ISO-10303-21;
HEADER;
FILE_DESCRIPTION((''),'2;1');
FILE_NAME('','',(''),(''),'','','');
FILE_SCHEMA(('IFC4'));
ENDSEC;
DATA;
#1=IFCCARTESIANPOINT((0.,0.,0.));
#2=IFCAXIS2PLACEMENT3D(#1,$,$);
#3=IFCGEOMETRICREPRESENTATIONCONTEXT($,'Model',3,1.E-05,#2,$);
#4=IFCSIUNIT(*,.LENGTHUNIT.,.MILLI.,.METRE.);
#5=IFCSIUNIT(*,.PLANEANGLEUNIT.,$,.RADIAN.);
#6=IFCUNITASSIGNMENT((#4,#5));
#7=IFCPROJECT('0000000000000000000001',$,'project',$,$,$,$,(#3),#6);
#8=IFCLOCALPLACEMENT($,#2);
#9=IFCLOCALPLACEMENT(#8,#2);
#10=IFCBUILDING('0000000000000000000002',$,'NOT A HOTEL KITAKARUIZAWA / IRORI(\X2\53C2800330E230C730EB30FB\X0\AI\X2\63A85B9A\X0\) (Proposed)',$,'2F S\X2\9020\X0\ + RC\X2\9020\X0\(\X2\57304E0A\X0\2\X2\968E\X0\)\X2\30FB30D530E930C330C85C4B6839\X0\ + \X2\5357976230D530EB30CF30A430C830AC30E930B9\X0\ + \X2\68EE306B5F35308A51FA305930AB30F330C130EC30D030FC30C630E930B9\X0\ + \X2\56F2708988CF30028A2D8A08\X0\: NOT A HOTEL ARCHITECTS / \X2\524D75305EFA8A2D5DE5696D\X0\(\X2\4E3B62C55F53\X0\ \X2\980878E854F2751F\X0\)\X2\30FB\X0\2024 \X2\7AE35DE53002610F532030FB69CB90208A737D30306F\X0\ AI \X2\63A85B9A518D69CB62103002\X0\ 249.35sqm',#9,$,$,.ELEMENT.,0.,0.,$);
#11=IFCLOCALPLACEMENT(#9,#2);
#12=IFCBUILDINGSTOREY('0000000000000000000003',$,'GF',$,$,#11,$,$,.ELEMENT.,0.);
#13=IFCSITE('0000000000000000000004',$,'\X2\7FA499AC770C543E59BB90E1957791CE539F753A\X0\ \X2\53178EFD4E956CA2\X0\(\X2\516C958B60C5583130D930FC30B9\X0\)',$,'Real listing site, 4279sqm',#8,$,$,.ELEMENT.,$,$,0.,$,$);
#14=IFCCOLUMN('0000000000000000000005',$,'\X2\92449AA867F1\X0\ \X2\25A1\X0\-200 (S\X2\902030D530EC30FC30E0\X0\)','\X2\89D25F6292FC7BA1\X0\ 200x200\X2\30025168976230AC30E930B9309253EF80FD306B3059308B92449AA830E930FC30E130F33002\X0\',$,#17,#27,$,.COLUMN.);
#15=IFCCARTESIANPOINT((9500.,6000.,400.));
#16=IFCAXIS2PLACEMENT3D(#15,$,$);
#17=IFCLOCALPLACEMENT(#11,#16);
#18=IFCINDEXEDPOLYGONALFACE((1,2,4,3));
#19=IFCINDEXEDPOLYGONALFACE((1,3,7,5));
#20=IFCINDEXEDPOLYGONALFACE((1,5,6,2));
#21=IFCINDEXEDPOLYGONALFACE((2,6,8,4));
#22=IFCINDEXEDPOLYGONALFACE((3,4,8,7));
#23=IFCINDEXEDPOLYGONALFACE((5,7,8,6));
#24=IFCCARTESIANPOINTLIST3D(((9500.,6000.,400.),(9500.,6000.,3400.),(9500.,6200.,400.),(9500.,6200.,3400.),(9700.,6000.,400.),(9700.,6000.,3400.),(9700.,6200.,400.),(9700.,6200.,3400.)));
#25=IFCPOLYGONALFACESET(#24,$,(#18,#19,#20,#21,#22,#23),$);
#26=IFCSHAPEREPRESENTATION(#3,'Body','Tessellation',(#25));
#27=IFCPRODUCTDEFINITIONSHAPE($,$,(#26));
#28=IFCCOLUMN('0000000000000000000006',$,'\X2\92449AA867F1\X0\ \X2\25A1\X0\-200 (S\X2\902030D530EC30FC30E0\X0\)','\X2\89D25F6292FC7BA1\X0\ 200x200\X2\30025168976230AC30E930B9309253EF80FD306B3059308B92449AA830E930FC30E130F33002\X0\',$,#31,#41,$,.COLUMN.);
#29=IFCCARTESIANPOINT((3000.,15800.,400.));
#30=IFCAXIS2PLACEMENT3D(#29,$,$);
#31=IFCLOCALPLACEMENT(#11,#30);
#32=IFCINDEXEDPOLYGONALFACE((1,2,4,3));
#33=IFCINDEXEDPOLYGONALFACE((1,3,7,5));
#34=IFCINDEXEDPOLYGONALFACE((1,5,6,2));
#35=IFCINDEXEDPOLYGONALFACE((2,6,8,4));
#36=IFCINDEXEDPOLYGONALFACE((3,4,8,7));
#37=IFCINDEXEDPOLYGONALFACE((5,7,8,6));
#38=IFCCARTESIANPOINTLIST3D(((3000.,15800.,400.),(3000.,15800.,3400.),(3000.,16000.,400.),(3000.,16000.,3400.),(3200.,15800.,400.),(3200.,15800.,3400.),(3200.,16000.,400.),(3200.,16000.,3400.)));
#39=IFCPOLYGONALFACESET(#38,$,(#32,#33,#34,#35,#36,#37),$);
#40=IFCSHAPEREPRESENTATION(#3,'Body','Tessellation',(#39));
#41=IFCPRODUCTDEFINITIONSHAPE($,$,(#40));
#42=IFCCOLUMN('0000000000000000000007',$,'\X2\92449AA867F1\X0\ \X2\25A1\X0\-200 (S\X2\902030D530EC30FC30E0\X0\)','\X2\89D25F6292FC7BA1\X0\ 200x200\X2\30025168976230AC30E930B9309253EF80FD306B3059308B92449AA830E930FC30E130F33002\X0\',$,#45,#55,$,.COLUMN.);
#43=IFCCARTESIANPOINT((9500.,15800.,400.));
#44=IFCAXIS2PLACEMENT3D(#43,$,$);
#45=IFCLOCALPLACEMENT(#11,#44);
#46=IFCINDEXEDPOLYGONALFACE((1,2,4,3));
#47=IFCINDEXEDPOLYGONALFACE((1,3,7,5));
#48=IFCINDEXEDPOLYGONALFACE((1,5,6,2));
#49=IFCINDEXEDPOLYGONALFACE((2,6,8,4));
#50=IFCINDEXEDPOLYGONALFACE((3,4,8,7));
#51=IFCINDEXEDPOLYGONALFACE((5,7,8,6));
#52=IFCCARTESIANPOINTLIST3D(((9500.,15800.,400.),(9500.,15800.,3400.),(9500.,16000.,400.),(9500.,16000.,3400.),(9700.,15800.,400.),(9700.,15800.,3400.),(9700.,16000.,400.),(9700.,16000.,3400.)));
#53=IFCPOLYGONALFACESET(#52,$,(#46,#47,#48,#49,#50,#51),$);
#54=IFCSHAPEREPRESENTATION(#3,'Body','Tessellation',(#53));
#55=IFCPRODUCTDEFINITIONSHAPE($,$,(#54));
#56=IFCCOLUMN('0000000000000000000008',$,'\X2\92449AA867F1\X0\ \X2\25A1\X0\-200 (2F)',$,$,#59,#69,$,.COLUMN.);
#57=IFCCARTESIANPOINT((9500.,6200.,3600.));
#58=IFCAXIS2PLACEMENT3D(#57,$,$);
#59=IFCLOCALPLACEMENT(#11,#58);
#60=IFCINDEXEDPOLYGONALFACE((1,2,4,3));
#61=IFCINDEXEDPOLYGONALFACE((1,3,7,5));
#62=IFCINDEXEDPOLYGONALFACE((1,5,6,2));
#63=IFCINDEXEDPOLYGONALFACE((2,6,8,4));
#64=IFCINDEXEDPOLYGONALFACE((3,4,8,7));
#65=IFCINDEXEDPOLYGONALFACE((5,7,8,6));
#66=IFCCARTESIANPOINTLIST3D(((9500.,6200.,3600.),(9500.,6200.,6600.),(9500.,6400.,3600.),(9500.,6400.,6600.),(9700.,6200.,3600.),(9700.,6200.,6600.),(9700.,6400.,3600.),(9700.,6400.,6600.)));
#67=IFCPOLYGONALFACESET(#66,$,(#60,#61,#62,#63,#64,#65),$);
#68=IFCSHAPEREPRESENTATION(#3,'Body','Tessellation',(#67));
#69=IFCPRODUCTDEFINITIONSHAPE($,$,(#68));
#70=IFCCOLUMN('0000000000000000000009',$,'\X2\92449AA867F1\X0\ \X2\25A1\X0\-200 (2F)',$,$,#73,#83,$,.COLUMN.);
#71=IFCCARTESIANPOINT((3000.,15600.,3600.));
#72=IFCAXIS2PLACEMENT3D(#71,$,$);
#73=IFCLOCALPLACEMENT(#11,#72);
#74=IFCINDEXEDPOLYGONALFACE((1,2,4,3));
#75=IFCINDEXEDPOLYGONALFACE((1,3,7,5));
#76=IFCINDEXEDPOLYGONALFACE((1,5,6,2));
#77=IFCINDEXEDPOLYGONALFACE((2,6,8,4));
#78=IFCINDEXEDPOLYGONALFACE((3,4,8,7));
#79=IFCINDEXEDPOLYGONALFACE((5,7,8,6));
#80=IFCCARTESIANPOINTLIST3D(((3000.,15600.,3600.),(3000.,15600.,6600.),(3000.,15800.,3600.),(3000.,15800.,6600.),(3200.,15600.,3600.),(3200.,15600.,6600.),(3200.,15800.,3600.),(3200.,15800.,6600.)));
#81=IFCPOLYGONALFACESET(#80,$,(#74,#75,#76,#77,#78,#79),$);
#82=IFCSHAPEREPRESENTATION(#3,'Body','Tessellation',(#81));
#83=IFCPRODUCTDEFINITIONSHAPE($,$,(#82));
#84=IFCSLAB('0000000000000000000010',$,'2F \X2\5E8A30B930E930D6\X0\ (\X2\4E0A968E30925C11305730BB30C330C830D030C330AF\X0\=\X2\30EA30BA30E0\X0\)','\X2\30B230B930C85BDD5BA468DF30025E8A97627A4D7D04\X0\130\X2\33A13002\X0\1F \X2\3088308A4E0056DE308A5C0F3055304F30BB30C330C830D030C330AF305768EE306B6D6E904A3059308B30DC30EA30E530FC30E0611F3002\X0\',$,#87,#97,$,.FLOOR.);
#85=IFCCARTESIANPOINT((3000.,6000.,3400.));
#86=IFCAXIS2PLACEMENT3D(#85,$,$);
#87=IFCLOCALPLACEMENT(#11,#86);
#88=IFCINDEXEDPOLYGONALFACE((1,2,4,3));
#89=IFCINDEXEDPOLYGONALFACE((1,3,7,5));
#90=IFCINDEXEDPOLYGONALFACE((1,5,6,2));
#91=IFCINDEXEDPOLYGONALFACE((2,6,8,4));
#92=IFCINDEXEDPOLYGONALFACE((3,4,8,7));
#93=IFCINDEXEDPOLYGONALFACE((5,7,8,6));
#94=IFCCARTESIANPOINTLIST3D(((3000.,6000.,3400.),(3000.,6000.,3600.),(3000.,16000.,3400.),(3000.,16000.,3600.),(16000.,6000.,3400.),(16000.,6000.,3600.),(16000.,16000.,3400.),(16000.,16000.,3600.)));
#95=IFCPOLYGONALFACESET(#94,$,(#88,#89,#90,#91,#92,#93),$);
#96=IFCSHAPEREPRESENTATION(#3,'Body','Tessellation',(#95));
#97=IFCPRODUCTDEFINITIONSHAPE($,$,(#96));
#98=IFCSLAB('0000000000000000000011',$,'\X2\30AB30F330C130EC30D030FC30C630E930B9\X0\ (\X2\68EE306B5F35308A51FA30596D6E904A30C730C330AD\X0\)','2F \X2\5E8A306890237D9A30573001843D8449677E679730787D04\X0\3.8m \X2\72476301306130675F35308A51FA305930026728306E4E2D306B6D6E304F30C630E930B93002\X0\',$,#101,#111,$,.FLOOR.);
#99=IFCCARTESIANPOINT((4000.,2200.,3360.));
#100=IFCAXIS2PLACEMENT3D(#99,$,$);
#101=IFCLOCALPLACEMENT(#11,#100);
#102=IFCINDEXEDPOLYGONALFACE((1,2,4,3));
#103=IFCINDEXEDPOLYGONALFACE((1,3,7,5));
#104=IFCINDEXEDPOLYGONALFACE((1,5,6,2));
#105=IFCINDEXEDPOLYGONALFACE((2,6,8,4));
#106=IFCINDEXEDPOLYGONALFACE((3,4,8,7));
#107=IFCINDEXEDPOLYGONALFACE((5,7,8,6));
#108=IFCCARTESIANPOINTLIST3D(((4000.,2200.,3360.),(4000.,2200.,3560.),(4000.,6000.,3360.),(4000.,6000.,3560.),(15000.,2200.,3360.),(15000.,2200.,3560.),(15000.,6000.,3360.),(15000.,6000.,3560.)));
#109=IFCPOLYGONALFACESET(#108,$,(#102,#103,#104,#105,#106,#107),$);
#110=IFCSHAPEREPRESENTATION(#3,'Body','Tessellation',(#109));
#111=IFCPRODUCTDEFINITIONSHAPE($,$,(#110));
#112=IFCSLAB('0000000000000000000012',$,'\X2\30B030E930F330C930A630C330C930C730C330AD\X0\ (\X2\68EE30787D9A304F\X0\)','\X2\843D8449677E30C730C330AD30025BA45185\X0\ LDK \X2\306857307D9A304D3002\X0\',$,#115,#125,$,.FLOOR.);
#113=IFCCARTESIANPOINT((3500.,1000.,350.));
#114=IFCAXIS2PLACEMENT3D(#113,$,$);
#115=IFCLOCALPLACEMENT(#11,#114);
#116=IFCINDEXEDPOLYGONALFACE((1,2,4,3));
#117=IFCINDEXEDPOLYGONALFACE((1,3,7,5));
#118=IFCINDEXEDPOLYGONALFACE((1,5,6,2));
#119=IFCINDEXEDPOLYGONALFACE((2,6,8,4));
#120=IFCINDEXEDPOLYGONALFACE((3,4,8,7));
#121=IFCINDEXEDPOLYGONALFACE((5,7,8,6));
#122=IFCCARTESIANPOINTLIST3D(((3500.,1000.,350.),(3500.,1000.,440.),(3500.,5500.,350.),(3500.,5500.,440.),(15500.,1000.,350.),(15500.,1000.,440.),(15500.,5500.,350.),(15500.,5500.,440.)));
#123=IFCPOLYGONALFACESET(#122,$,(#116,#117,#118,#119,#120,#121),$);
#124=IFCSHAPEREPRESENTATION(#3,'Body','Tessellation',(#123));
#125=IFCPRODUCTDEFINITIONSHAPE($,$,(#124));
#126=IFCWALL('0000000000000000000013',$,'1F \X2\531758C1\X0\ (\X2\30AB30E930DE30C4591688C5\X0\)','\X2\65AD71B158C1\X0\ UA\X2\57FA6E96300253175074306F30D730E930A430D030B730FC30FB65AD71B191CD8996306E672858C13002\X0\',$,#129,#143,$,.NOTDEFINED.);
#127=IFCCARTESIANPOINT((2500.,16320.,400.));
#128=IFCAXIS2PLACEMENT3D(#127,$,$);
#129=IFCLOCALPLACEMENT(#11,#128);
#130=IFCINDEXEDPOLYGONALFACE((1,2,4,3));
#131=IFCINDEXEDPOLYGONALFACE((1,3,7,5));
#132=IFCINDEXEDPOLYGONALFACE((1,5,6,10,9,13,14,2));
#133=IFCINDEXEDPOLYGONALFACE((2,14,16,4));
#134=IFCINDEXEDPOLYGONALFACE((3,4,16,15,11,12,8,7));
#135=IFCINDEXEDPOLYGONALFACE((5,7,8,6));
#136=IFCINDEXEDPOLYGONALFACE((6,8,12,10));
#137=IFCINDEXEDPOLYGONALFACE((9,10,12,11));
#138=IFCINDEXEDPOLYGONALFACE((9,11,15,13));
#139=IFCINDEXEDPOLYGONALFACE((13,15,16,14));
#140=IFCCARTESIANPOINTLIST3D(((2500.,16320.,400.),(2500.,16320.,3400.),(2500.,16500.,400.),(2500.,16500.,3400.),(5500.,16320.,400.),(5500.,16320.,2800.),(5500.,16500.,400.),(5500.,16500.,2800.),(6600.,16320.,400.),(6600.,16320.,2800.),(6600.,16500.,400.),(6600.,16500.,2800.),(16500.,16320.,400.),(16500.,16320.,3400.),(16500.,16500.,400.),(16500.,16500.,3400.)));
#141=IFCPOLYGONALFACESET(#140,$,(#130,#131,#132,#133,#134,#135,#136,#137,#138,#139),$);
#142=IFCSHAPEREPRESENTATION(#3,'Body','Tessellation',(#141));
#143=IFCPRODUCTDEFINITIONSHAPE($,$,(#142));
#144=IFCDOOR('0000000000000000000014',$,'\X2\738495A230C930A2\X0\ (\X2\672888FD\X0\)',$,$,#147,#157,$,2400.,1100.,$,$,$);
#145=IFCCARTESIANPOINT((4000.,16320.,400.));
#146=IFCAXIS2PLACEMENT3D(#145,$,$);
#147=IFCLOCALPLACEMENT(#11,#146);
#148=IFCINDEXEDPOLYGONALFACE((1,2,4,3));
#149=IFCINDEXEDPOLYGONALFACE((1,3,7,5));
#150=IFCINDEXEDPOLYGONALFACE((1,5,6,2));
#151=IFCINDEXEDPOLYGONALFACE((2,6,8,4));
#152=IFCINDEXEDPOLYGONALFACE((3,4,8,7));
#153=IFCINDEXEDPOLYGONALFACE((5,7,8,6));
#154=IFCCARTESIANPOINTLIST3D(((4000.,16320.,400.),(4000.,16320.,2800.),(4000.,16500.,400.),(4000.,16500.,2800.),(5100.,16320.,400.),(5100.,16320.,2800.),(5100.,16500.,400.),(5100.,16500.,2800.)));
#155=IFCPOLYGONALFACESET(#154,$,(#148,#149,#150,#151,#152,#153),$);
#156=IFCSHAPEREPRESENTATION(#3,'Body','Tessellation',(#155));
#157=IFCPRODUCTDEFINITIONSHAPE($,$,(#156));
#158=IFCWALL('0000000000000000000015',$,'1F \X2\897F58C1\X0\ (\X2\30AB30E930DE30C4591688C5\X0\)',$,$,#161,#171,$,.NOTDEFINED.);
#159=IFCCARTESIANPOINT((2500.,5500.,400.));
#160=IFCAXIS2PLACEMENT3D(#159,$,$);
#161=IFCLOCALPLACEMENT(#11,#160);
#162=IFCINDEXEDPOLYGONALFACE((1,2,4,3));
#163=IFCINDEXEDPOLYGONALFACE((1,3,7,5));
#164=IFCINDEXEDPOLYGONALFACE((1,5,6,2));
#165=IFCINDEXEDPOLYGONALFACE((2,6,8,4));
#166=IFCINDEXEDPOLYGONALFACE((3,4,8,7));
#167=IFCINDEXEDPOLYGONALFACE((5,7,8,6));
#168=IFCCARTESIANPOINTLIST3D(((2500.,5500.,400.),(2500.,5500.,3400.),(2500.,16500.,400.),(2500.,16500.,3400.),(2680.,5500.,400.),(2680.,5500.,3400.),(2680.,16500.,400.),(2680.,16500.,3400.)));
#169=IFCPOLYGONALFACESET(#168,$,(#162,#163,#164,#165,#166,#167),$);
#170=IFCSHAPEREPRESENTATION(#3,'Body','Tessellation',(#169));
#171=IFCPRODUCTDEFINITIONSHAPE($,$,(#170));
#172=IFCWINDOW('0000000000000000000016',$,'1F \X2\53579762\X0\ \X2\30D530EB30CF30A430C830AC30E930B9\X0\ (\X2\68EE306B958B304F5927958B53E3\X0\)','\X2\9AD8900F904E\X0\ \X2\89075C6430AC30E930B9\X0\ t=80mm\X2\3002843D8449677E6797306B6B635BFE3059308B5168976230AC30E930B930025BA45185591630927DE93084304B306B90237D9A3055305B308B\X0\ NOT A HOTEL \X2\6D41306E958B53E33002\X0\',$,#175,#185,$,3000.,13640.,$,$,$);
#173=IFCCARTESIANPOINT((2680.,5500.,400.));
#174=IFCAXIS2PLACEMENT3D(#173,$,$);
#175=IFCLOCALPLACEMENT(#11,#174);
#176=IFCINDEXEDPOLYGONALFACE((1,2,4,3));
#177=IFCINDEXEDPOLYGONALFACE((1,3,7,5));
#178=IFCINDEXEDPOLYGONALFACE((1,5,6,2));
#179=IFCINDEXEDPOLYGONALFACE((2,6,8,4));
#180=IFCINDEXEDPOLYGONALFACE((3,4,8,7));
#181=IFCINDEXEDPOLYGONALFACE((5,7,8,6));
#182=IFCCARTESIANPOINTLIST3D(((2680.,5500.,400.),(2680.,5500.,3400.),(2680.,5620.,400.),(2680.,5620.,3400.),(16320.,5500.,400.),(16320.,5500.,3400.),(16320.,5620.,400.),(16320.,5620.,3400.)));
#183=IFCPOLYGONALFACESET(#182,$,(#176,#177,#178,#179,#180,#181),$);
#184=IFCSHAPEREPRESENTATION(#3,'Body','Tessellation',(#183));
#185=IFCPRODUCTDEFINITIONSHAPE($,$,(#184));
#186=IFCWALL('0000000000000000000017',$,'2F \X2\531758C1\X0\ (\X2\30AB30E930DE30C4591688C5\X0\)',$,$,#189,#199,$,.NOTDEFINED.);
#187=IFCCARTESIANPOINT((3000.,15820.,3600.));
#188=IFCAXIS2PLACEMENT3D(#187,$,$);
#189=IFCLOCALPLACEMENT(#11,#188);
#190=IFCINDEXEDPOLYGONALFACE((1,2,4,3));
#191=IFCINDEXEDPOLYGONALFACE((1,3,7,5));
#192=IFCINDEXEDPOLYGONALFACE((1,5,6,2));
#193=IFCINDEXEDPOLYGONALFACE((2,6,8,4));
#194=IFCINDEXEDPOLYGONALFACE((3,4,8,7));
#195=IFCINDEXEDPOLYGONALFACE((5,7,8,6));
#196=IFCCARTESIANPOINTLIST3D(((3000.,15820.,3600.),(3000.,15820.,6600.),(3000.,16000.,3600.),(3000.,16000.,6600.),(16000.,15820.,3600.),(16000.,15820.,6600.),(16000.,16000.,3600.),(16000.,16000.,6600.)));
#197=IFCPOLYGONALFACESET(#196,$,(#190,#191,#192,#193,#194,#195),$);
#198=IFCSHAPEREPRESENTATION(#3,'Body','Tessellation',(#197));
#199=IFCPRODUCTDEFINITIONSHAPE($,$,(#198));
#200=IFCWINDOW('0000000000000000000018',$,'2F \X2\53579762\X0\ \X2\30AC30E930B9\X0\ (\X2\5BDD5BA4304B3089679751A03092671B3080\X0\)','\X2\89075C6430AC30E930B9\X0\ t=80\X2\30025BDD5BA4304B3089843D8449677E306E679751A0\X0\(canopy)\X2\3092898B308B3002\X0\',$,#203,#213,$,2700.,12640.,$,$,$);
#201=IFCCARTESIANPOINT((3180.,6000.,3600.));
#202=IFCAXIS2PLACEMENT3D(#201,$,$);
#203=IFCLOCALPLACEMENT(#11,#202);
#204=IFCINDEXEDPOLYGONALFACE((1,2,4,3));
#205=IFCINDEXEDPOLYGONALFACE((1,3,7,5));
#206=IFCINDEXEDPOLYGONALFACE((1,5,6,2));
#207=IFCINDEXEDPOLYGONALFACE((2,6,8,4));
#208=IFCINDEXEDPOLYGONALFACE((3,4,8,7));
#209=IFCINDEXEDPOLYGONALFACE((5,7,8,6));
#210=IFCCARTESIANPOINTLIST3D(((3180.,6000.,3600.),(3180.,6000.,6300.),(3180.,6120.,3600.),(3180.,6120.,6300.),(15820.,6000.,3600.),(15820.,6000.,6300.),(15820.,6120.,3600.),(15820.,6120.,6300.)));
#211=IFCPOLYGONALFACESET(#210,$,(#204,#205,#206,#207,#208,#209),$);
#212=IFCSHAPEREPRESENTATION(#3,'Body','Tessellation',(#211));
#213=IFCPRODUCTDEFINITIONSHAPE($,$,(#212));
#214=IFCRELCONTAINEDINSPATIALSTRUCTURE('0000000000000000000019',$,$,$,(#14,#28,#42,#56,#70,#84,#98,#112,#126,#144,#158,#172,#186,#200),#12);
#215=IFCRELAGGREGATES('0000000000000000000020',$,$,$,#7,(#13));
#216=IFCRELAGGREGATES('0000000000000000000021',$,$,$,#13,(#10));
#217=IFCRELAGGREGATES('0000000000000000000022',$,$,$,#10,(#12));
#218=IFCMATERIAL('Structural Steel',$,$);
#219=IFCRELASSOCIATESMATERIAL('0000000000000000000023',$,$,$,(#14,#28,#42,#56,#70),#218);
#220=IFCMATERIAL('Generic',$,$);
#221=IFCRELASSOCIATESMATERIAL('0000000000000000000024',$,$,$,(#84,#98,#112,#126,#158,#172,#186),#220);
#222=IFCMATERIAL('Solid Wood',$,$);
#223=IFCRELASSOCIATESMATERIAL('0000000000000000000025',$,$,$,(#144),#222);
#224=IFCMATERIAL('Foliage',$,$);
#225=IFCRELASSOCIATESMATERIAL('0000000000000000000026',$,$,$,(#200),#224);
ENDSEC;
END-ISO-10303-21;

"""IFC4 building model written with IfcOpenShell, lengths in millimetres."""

from ifc_helpers import new_model, si_unit, frame, frame_2d, origin, place, context, project, spatial, rectangle, extrude, material, element, fill, save


model = new_model("IFC4")

# Units and contexts
model_context = context("Model", 3, precision=1e-05, world=origin())
ifc_project = project(units=[si_unit("LENGTHUNIT", "METRE", prefix="MILLI"), si_unit("PLANEANGLEUNIT", "RADIAN")], contexts=[model_context])

# Site, building, storey
site_placement = place(None, origin())
site = spatial("IfcSite", under=ifc_project, at=site_placement, Name="群馬県吾妻郡長野原町 北軽井沢(公開情報ベース)", ObjectType="Real listing site, 4279sqm", CompositionType="ELEMENT", RefElevation=0.0)
building_placement = place(site_placement, origin())
building = spatial("IfcBuilding", under=site, at=building_placement, Name="NOT A HOTEL KITAKARUIZAWA / IRORI(参考モデル・AI推定) (Proposed)", ObjectType="2F S造 + RC造(地上2階)・フラット屋根 + 南面フルハイトガラス + 森に張り出すカンチレバーテラス + 囲炉裏。設計: NOT A HOTEL ARCHITECTS / 前田建設工業(主担当 須磨哲生)・2024 竣工。意匠・構造詳細は AI 推定再構成。 249.35sqm", CompositionType="ELEMENT", ElevationOfRefHeight=0.0, ElevationOfTerrain=0.0)
storey_placement = place(building_placement, origin())
storey = spatial("IfcBuildingStorey", under=building, at=storey_placement, Name="GF", CompositionType="ELEMENT", Elevation=0.0)

# Columns
ifc_material_1 = material(Name="Structural Steel")
column_1_placement = place(storey_placement, frame((9500.0, 6000.0, 400.0)))
element("IfcColumn", 1, at=column_1_placement, inside=storey, material=ifc_material_1, Name="鉄骨柱 □-200 (S造フレーム)", Description="角形鋼管 200x200。全面ガラスを可能にする鉄骨ラーメン。", PredefinedType="COLUMN", context=model_context, shape_type="SweptSolid", body=[
    extrude(rectangle(XDim=200.0, YDim=200.0, at=frame_2d((100.0, 100.0))), frame((9500.0, 6000.0, 400.0)), (0.0, 0.0, 1.0), 3000.0),
])
column_2_placement = place(storey_placement, frame((3000.0, 15800.0, 400.0)))
element("IfcColumn", 2, at=column_2_placement, inside=storey, material=ifc_material_1, Name="鉄骨柱 □-200 (S造フレーム)", Description="角形鋼管 200x200。全面ガラスを可能にする鉄骨ラーメン。", PredefinedType="COLUMN", context=model_context, shape_type="SweptSolid", body=[
    extrude(rectangle(XDim=200.0, YDim=200.0, at=frame_2d((100.0, 100.0))), frame((3000.0, 15800.0, 400.0)), (0.0, 0.0, 1.0), 3000.0),
])
column_3_placement = place(storey_placement, frame((9500.0, 15800.0, 400.0)))
element("IfcColumn", 3, at=column_3_placement, inside=storey, material=ifc_material_1, Name="鉄骨柱 □-200 (S造フレーム)", Description="角形鋼管 200x200。全面ガラスを可能にする鉄骨ラーメン。", PredefinedType="COLUMN", context=model_context, shape_type="SweptSolid", body=[
    extrude(rectangle(XDim=200.0, YDim=200.0, at=frame_2d((100.0, 100.0))), frame((9500.0, 15800.0, 400.0)), (0.0, 0.0, 1.0), 3000.0),
])
column_4_placement = place(storey_placement, frame((9500.0, 6200.0, 3600.0)))
element("IfcColumn", 4, at=column_4_placement, inside=storey, material=ifc_material_1, Name="鉄骨柱 □-200 (2F)", PredefinedType="COLUMN", context=model_context, shape_type="SweptSolid", body=[
    extrude(rectangle(XDim=200.0, YDim=200.0, at=frame_2d((100.0, 100.0))), frame((9500.0, 6200.0, 3600.0)), (0.0, 0.0, 1.0), 3000.0),
])
column_5_placement = place(storey_placement, frame((3000.0, 15600.0, 3600.0)))
element("IfcColumn", 5, at=column_5_placement, inside=storey, material=ifc_material_1, Name="鉄骨柱 □-200 (2F)", PredefinedType="COLUMN", context=model_context, shape_type="SweptSolid", body=[
    extrude(rectangle(XDim=200.0, YDim=200.0, at=frame_2d((100.0, 100.0))), frame((3000.0, 15600.0, 3600.0)), (0.0, 0.0, 1.0), 3000.0),
])

# Slabs
ifc_material_2 = material(Name="Generic")
slab_1_placement = place(storey_placement, frame((3000.0, 6000.0, 3400.0)))
element("IfcSlab", 6, at=slab_1_placement, inside=storey, material=ifc_material_2, Name="2F 床スラブ (上階を少しセットバック=リズム)", Description="ゲスト寝室棟。床面積約130㎡。1F より一回り小さくセットバックし森に浮遊するボリューム感。", PredefinedType="FLOOR", context=model_context, shape_type="SweptSolid", body=[
    extrude(rectangle(XDim=13000.0, YDim=10000.0, at=frame_2d((6500.0, 5000.0))), frame((3000.0, 6000.0, 3400.0)), (0.0, 0.0, 1.0), 200.0),
])
slab_2_placement = place(storey_placement, frame((4000.0, 2200.0, 3360.0)))
element("IfcSlab", 7, at=slab_2_placement, inside=storey, material=ifc_material_2, Name="カンチレバーテラス (森に張り出す浮遊デッキ)", Description="2F 床と連続し、落葉松林へ約3.8m 片持ちで張り出す。木の中に浮くテラス。", PredefinedType="FLOOR", context=model_context, shape_type="SweptSolid", body=[
    extrude(rectangle(XDim=11000.0, YDim=3800.0, at=frame_2d((5500.0, 1900.0))), frame((4000.0, 2200.0, 3360.0)), (0.0, 0.0, 1.0), 200.0),
])
slab_3_placement = place(storey_placement, frame((3500.0, 1000.0, 350.0)))
element("IfcSlab", 8, at=slab_3_placement, inside=storey, material=ifc_material_2, Name="グランドウッドデッキ (森へ続く)", Description="落葉松デッキ。室内 LDK と地続き。", PredefinedType="FLOOR", context=model_context, shape_type="SweptSolid", body=[
    extrude(rectangle(XDim=12000.0, YDim=4500.0, at=frame_2d((6000.0, 2250.0))), frame((3500.0, 1000.0, 350.0)), (0.0, 0.0, 1.0), 90.0),
])

# Wall, opening, door
wall_1_placement = place(storey_placement, frame((2500.0, 16320.0, 400.0)))
wall_1 = element("IfcWall", 9, at=wall_1_placement, inside=storey, material=ifc_material_2, Name="1F 北壁 (カラマツ外装)", Description="断熱壁 UA基準。北側はプライバシー・断熱重視の木壁。", PredefinedType="NOTDEFINED", context=model_context, shape_type="SweptSolid", body=[
    extrude(rectangle(XDim=14000.0, YDim=180.0, at=frame_2d((7000.0, 90.0))), frame((2500.0, 16320.0, 400.0)), (0.0, 0.0, 1.0), 3000.0),
])
opening_placement = place(storey_placement, frame((4000.0, 16320.0, 400.0)))
opening = element("IfcOpeningElement", 10, at=opening_placement, cuts=wall_1, PredefinedType="NOTDEFINED", context=model_context, shape_type="SweptSolid", body=[
    extrude(rectangle(XDim=1100.0, YDim=180.0, at=frame_2d((550.0, 90.0))), frame((4000.0, 16320.0, 400.0)), (0.0, 0.0, 1.0), 2400.0),
])
ifc_material_3 = material(Name="Solid Wood")
door_placement = place(storey_placement, frame((4000.0, 16320.0, 400.0)))
door = element("IfcDoor", 11, at=door_placement, inside=storey, material=ifc_material_3, Name="玄関ドア (木製)", OverallHeight=2400.0, OverallWidth=1100.0, context=model_context, shape_type="SweptSolid", body=[
    extrude(rectangle(XDim=1100.0, YDim=180.0, at=frame_2d((550.0, 90.0))), frame((4000.0, 16320.0, 400.0)), (0.0, 0.0, 1.0), 2400.0),
])
fill(opening, door)

# Wall
wall_2_placement = place(storey_placement, frame((2500.0, 5500.0, 400.0)))
element("IfcWall", 12, at=wall_2_placement, inside=storey, material=ifc_material_2, Name="1F 西壁 (カラマツ外装)", PredefinedType="NOTDEFINED", context=model_context, shape_type="SweptSolid", body=[
    extrude(rectangle(XDim=180.0, YDim=11000.0, at=frame_2d((90.0, 5500.0))), frame((2500.0, 5500.0, 400.0)), (0.0, 0.0, 1.0), 3000.0),
])

# Window
window_1_placement = place(storey_placement, frame((2680.0, 5500.0, 400.0)))
element("IfcWindow", 13, at=window_1_placement, inside=storey, material=ifc_material_2, Name="1F 南面 フルハイトガラス (森に開く大開口)", Description="高透過 複層ガラス t=80mm。落葉松林に正対する全面ガラス。室内外を緩やかに連続させる NOT A HOTEL 流の開口。", OverallHeight=3000.0, OverallWidth=13640.0, context=model_context, shape_type="SweptSolid", body=[
    extrude(rectangle(XDim=13640.0, YDim=120.0, at=frame_2d((6820.0, 60.0))), frame((2680.0, 5500.0, 400.0)), (0.0, 0.0, 1.0), 3000.0),
])

# Wall
wall_3_placement = place(storey_placement, frame((3000.0, 15820.0, 3600.0)))
element("IfcWall", 14, at=wall_3_placement, inside=storey, material=ifc_material_2, Name="2F 北壁 (カラマツ外装)", PredefinedType="NOTDEFINED", context=model_context, shape_type="SweptSolid", body=[
    extrude(rectangle(XDim=13000.0, YDim=180.0, at=frame_2d((6500.0, 90.0))), frame((3000.0, 15820.0, 3600.0)), (0.0, 0.0, 1.0), 3000.0),
])

# Window
ifc_material_4 = material(Name="Foliage")
window_2_placement = place(storey_placement, frame((3180.0, 6000.0, 3600.0)))
element("IfcWindow", 15, at=window_2_placement, inside=storey, material=ifc_material_4, Name="2F 南面 ガラス (寝室から林冠を望む)", Description="複層ガラス t=80。寝室から落葉松の林冠(canopy)を見る。", OverallHeight=2700.0, OverallWidth=12640.0, context=model_context, shape_type="SweptSolid", body=[
    extrude(rectangle(XDim=12640.0, YDim=120.0, at=frame_2d((6320.0, 60.0))), frame((3180.0, 6000.0, 3600.0)), (0.0, 0.0, 1.0), 2700.0),
])

save(model, "model.ifc")
